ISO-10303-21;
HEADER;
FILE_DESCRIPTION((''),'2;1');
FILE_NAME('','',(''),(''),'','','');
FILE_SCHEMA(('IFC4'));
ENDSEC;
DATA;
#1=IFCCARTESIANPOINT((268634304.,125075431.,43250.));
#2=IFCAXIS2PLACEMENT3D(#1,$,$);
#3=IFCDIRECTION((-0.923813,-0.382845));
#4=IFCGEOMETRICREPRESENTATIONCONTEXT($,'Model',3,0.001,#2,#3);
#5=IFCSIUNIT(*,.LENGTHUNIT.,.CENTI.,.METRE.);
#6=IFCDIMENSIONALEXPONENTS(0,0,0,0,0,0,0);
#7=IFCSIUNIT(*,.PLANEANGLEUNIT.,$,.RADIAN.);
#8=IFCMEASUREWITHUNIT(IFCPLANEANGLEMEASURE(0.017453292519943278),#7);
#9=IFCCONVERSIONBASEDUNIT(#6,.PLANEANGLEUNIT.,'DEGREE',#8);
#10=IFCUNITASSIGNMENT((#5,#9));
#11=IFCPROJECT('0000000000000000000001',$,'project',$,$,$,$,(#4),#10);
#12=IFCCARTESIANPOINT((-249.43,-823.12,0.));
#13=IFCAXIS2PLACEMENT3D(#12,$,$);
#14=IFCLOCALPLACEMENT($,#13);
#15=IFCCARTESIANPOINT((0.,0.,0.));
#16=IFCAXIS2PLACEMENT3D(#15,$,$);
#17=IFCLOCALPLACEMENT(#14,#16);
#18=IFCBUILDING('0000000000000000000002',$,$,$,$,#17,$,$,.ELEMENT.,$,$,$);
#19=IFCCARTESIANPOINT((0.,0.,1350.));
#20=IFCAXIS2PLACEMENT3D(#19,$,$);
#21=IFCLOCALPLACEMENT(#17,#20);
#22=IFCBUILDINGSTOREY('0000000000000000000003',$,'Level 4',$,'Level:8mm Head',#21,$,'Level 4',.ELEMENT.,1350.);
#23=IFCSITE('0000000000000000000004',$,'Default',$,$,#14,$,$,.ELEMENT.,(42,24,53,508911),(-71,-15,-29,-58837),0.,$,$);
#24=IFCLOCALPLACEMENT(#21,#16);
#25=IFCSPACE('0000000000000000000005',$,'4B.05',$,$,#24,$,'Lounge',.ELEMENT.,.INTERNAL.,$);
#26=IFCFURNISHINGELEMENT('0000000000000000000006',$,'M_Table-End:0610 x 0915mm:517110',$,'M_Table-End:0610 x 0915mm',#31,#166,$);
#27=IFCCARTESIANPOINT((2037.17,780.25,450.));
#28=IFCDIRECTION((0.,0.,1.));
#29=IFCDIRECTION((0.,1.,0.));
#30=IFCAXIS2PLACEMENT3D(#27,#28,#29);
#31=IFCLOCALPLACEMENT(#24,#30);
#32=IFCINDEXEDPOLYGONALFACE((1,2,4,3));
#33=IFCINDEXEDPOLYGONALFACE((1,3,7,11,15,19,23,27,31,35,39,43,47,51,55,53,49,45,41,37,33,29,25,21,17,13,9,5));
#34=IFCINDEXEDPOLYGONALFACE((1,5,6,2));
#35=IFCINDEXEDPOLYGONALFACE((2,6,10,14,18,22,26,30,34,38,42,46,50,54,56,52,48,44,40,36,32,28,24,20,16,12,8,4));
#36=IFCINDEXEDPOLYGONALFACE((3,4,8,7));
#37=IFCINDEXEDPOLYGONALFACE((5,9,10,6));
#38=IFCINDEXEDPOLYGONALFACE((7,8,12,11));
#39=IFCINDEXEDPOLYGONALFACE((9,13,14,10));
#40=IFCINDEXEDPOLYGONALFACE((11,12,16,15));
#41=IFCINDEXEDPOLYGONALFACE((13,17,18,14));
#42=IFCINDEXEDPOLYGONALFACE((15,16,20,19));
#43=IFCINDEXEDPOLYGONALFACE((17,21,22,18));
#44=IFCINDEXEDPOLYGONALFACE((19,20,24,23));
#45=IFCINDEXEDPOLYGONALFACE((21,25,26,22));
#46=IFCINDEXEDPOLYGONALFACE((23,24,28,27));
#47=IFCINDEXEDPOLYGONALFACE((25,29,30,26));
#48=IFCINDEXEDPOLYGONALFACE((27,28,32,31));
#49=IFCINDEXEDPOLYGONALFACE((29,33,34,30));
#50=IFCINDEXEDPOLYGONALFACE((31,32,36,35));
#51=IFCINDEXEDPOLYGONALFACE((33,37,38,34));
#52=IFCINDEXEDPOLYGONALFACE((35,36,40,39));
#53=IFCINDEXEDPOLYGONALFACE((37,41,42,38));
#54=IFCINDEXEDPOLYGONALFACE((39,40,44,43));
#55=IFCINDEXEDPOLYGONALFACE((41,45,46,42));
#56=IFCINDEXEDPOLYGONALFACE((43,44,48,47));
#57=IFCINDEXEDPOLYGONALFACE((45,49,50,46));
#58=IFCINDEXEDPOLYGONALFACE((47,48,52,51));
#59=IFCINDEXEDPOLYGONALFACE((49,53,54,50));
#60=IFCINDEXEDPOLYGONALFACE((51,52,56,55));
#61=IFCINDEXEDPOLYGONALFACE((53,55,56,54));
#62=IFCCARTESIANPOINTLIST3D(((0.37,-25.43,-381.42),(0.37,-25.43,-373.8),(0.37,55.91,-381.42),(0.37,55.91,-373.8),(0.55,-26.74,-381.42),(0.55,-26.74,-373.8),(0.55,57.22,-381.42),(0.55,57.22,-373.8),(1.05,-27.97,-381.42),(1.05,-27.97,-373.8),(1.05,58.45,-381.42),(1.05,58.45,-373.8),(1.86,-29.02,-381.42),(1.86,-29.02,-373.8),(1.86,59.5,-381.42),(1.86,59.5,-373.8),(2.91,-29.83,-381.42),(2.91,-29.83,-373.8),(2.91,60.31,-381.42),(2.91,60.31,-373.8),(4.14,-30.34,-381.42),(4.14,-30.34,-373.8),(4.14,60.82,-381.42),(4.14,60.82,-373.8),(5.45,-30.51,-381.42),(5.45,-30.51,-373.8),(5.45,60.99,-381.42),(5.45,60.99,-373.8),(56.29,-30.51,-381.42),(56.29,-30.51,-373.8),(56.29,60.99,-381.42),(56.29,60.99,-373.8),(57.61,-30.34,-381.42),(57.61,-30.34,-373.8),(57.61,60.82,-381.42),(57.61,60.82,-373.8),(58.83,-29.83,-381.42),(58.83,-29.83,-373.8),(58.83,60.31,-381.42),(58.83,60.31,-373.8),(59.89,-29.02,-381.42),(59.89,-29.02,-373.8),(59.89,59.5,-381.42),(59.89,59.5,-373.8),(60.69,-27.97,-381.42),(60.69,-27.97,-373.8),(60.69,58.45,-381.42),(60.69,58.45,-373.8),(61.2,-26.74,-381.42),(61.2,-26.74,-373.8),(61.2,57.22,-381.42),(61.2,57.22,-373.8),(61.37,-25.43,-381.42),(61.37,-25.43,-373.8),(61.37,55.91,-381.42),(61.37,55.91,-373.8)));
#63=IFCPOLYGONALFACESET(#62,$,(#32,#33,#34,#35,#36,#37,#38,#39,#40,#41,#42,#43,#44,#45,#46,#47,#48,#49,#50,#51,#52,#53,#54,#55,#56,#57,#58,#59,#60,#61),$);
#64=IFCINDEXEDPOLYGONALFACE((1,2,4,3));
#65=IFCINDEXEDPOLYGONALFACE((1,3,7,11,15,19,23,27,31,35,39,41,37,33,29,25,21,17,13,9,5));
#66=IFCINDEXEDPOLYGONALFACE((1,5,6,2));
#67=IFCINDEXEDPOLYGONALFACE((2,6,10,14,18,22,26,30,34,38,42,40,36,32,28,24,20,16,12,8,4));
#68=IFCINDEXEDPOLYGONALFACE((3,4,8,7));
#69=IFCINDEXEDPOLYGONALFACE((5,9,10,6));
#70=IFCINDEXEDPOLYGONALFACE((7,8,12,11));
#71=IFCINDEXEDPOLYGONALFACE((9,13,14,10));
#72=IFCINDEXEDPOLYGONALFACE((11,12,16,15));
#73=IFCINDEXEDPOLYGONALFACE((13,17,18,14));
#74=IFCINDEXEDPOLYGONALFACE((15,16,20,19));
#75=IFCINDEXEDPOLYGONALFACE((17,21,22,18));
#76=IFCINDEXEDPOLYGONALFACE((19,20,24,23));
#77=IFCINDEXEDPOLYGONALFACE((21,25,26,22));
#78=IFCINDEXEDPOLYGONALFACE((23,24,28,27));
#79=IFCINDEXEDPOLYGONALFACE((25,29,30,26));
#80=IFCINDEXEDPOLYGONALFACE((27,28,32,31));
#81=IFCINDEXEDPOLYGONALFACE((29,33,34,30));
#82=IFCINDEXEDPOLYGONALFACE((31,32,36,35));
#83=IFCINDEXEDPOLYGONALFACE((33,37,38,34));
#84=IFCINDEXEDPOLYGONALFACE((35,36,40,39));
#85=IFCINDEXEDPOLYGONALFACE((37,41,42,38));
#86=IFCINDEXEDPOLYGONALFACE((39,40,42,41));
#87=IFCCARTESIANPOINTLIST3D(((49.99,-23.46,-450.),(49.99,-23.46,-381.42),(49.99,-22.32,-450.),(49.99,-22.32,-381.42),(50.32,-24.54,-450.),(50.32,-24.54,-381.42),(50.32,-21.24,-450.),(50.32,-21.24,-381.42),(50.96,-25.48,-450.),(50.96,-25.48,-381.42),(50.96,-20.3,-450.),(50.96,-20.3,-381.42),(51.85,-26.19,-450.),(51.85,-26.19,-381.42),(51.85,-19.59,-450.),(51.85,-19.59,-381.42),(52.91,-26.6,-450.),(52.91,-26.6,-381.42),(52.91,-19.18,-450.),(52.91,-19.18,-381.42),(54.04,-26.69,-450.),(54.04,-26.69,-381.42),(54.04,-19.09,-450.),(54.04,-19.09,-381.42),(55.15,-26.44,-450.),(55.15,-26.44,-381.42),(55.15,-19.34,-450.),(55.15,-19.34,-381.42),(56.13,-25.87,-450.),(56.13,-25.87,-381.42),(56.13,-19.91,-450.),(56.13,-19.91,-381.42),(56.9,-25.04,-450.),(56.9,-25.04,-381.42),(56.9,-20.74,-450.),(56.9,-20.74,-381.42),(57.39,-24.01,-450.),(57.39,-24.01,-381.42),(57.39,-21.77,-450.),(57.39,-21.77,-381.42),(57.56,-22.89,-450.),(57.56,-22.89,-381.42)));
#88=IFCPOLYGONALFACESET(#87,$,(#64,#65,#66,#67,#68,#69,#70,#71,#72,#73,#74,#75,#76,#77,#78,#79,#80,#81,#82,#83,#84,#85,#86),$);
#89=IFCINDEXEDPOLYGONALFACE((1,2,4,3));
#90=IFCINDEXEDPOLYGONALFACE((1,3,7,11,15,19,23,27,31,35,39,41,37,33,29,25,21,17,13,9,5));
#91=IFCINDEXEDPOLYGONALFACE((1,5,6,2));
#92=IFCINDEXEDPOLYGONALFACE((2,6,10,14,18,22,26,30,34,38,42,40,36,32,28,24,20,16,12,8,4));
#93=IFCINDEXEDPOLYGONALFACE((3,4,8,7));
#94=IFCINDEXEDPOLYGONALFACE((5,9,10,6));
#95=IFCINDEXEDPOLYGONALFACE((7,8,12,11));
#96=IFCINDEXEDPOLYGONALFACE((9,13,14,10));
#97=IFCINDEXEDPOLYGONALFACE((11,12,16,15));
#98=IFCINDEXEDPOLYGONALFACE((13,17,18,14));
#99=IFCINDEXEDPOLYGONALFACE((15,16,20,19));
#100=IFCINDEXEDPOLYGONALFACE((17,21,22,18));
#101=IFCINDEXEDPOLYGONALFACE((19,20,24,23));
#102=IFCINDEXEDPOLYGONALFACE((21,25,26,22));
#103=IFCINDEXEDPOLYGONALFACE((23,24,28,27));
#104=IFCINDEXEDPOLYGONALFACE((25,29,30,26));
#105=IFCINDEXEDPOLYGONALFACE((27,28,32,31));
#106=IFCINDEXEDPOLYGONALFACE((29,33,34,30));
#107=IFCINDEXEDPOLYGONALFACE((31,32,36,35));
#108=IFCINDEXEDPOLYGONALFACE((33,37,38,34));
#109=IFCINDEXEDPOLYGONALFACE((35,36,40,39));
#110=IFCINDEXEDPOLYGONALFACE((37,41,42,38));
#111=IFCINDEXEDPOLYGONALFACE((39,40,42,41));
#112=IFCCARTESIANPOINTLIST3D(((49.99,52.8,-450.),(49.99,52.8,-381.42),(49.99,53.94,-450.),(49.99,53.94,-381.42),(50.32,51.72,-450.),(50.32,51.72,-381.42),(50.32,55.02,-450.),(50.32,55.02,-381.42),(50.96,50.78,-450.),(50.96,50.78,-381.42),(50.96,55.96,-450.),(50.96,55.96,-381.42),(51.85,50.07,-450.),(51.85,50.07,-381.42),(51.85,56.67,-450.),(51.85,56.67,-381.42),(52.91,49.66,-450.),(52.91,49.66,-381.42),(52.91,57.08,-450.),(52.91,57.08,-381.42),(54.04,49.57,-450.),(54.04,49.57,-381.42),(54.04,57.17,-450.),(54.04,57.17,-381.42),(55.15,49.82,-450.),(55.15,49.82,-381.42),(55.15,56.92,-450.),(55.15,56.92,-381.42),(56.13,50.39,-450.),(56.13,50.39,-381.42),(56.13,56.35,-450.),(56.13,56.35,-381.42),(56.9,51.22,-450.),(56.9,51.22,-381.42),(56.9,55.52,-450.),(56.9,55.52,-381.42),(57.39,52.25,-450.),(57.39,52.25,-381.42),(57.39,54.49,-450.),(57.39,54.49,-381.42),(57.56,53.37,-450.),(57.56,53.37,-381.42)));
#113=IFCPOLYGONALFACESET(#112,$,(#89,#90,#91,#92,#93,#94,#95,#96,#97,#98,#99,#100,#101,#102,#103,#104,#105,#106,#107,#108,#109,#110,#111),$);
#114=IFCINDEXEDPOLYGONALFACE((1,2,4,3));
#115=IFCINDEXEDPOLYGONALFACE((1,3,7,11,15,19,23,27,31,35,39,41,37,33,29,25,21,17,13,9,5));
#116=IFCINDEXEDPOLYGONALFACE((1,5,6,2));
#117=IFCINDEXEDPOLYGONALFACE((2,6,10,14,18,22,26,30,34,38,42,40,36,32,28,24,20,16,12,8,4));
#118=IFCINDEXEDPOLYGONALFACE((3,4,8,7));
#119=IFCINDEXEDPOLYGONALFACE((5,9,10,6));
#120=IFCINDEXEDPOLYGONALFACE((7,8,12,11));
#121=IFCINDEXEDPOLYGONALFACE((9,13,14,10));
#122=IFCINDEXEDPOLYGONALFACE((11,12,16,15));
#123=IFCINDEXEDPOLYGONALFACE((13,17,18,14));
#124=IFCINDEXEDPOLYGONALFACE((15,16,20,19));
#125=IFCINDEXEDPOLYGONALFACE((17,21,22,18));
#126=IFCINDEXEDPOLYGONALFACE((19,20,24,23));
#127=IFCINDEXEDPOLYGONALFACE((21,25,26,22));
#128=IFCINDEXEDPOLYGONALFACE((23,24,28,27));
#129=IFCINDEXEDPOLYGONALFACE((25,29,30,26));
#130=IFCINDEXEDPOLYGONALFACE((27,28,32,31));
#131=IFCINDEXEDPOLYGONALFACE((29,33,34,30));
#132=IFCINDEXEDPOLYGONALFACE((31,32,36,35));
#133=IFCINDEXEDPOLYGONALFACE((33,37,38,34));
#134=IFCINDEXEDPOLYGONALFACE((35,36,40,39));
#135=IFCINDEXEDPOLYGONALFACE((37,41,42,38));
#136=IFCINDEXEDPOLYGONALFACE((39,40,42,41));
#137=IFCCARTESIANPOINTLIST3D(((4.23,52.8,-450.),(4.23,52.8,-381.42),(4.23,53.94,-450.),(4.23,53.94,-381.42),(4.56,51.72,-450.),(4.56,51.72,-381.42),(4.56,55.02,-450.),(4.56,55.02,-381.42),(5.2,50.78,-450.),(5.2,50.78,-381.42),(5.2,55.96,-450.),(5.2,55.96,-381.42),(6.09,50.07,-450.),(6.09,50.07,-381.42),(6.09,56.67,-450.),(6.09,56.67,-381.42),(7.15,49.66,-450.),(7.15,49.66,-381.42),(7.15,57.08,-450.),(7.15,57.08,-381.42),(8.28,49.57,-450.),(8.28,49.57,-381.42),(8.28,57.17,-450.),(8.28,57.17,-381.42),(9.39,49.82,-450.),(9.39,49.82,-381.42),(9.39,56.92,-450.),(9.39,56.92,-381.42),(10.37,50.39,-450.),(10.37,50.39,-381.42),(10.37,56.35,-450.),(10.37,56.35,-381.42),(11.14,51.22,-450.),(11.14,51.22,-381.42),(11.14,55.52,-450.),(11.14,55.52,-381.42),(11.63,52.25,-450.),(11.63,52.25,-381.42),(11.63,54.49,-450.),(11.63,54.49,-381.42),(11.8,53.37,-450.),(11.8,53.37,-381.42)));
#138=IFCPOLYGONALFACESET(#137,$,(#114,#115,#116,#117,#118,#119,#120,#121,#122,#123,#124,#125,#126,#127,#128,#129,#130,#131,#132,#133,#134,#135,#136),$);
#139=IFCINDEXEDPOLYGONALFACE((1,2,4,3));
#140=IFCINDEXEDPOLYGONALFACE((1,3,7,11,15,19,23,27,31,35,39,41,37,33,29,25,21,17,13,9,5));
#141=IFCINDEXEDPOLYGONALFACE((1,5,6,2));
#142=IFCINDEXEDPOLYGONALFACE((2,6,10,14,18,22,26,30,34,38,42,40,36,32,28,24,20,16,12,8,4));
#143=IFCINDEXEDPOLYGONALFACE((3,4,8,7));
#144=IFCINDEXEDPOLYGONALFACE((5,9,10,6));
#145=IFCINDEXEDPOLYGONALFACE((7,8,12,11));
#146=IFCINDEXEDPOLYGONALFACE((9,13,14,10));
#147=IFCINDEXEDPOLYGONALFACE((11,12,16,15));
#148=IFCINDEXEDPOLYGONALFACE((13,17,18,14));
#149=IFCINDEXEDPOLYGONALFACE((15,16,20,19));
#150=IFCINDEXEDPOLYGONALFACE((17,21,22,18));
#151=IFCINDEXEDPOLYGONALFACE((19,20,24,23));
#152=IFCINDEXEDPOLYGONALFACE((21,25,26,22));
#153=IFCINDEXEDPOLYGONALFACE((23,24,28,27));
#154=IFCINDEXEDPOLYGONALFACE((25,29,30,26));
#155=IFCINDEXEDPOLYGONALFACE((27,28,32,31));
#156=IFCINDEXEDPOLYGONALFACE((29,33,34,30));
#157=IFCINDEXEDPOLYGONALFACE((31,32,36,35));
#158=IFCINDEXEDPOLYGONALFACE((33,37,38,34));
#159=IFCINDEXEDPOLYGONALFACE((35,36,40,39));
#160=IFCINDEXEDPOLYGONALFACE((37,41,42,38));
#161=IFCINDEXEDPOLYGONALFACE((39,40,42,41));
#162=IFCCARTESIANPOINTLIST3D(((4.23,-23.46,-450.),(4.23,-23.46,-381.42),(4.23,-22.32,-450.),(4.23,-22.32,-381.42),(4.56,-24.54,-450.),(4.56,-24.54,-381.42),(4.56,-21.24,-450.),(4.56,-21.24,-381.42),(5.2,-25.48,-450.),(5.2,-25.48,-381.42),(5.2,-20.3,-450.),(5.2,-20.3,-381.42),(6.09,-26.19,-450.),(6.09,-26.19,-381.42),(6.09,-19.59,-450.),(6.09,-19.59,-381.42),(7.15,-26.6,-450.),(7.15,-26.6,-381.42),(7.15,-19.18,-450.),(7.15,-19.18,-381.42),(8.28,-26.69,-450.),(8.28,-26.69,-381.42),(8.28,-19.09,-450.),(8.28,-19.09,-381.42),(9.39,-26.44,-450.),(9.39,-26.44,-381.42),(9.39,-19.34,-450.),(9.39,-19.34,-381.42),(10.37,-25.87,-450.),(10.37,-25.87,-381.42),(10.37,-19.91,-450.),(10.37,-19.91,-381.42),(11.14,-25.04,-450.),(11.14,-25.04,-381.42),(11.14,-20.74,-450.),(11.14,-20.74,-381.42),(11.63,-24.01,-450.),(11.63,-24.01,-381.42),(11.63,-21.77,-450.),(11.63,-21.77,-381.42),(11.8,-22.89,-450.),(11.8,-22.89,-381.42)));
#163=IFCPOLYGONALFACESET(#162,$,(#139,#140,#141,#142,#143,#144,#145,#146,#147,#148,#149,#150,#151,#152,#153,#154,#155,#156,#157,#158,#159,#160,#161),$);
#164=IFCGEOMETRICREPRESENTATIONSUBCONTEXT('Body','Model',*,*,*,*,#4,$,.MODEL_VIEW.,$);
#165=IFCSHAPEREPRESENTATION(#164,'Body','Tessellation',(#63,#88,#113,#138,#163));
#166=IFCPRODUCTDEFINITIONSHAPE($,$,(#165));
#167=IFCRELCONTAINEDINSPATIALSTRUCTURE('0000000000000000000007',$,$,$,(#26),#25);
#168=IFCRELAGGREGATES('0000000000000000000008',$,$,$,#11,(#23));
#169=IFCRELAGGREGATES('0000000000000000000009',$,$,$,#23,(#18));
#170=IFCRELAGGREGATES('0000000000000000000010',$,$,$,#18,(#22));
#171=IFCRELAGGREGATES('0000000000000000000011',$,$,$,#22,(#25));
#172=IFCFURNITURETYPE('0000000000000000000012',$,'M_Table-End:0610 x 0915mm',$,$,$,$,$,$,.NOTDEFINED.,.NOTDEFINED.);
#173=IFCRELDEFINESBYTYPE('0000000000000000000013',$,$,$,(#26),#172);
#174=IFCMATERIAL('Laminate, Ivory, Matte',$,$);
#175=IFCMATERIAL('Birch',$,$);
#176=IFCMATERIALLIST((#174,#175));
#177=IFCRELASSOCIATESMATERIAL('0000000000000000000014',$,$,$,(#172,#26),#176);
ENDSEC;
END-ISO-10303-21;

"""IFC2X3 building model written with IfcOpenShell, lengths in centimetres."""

from ifc_helpers import new_model, entity, si_unit, converted_unit, direction, frame, frame_2d, origin, place, context, subcontext, project, spatial, polyline, circle_curve, parameter, trimmed, segment, composite_curve, circle, outline, extrude, source, transform, mapped, material, material_list, type_object, type_shapes, element, save


model = new_model("IFC2X3")

# Units and contexts
model_context = context("Model", 3, precision=0.001, world=frame((268634304.0, 125075431.0, 43250.0)), true_north=direction((-0.923813, -0.382845)))
body_context = subcontext(model_context, "Body", "Model", "MODEL_VIEW")
ifc_project = project(units=[si_unit("LENGTHUNIT", "METRE", prefix="CENTI"), converted_unit("PLANEANGLEUNIT", "DEGREE", entity("IfcPlaneAngleMeasure", 0.017453292519943278), si_unit("PLANEANGLEUNIT", "RADIAN"), dimensions=[0, 0, 0, 0, 0, 0, 0])], contexts=[model_context])

# Site, building, storey
site_placement = place(None, frame((-249.43, -823.12, 0.0)))
site = spatial("IfcSite", under=ifc_project, at=site_placement, Name="Default", CompositionType="ELEMENT", RefLatitude=(42, 24, 53, 508911), RefLongitude=(-71, -15, -29, -58837), RefElevation=0.0)
building_placement = place(site_placement, origin())
building = spatial("IfcBuilding", under=site, at=building_placement, CompositionType="ELEMENT")
storey_placement = place(building_placement, frame((0.0, 0.0, 1350.0)))
storey = spatial("IfcBuildingStorey", under=building, at=storey_placement, Name="Level 4", ObjectType="Level:8mm Head", LongName="Level 4", CompositionType="ELEMENT", Elevation=1350.0)

# Shared definitions
space_1_placement = place(storey_placement, origin())
space_1 = spatial("IfcSpace", under=storey, at=space_1_placement, Name="4B.05", LongName="Lounge", CompositionType="ELEMENT", InteriorOrExteriorSpace="INTERNAL")

# Furnishing element
ifc_material_1 = material(Name="Laminate, Ivory, Matte")
ifc_material_2 = material(Name="Birch")
ifc_material_list_1 = material_list([ifc_material_1, ifc_material_2])
furniture_type_1 = type_object("IfcFurnitureType", Name="M_Table-End:0610 x 0915mm", AssemblyPlace="NOTDEFINED", material=ifc_material_list_1)
shared_shape_1 = source(origin(), body_context, "Body", "SweptSolid", [
    extrude(outline(composite_curve([segment(trimmed(circle_curve(frame_2d((25.42, -40.67), x_axis=(1.0, 0.0)), 5.08), [parameter(270.0)], [parameter(0.0)], True, "PARAMETER"), True, "CONTINUOUS"), segment(polyline([(30.5, -40.67), (30.5, 40.67)]), True, "CONTINUOUS"), segment(trimmed(circle_curve(frame_2d((25.42, 40.67), x_axis=(1.0, 0.0)), 5.08), [parameter(360.0)], [parameter(90.0)], True, "PARAMETER"), True, "CONTINUOUS"), segment(polyline([(25.42, 45.75), (-25.42, 45.75)]), True, "CONTINUOUS"), segment(trimmed(circle_curve(frame_2d((-25.42, 40.67), x_axis=(1.0, 0.0)), 5.08), [parameter(90.0)], [parameter(180.0)], True, "PARAMETER"), True, "CONTINUOUS"), segment(polyline([(-30.5, 40.67), (-30.5, -40.67)]), True, "CONTINUOUS"), segment(trimmed(circle_curve(frame_2d((-25.42, -40.67), x_axis=(1.0, 0.0)), 5.08), [parameter(180.0)], [parameter(270.0)], True, "PARAMETER"), True, "CONTINUOUS"), segment(polyline([(-25.42, -45.75), (25.42, -45.75)]), True, "CONTINUOUS")], self_intersect=False)), frame((30.87, 15.24, -381.42)), (0.0, 0.0, 1.0), 7.62),
    extrude(circle(Radius=3.81, at=frame_2d((0.0, 0.0), x_axis=(1.0, 0.0))), frame((53.75, -22.89, -450.0)), (0.0, 0.0, 1.0), 68.58),
    extrude(circle(Radius=3.81, at=frame_2d((0.0, 0.0), x_axis=(1.0, 0.0))), frame((53.75, 53.37, -450.0)), (0.0, 0.0, 1.0), 68.58),
    extrude(circle(Radius=3.81, at=frame_2d((0.0, 0.0), x_axis=(1.0, 0.0))), frame((7.99, 53.37, -450.0)), (0.0, 0.0, 1.0), 68.58),
    extrude(circle(Radius=3.81, at=frame_2d((0.0, 0.0), x_axis=(1.0, 0.0))), frame((7.99, -22.89, -450.0)), (0.0, 0.0, 1.0), 68.58),
])
type_shapes(furniture_type_1, [shared_shape_1])
furnishing_1_placement = place(space_1_placement, frame((2037.17, 780.25, 450.0), z_axis=(0.0, 0.0, 1.0), x_axis=(0.0, 1.0, 0.0)))
element("IfcFurnishingElement", 1, at=furnishing_1_placement, inside=space_1, type_object=furniture_type_1, material=ifc_material_list_1, Name="M_Table-End:0610 x 0915mm:517110", ObjectType="M_Table-End:0610 x 0915mm", context=body_context, shape_type="MappedRepresentation", body=[
    mapped(shared_shape_1, transform((0.0, 0.0, 0.0), scale=1.0)),
])

save(model, "model.ifc")
